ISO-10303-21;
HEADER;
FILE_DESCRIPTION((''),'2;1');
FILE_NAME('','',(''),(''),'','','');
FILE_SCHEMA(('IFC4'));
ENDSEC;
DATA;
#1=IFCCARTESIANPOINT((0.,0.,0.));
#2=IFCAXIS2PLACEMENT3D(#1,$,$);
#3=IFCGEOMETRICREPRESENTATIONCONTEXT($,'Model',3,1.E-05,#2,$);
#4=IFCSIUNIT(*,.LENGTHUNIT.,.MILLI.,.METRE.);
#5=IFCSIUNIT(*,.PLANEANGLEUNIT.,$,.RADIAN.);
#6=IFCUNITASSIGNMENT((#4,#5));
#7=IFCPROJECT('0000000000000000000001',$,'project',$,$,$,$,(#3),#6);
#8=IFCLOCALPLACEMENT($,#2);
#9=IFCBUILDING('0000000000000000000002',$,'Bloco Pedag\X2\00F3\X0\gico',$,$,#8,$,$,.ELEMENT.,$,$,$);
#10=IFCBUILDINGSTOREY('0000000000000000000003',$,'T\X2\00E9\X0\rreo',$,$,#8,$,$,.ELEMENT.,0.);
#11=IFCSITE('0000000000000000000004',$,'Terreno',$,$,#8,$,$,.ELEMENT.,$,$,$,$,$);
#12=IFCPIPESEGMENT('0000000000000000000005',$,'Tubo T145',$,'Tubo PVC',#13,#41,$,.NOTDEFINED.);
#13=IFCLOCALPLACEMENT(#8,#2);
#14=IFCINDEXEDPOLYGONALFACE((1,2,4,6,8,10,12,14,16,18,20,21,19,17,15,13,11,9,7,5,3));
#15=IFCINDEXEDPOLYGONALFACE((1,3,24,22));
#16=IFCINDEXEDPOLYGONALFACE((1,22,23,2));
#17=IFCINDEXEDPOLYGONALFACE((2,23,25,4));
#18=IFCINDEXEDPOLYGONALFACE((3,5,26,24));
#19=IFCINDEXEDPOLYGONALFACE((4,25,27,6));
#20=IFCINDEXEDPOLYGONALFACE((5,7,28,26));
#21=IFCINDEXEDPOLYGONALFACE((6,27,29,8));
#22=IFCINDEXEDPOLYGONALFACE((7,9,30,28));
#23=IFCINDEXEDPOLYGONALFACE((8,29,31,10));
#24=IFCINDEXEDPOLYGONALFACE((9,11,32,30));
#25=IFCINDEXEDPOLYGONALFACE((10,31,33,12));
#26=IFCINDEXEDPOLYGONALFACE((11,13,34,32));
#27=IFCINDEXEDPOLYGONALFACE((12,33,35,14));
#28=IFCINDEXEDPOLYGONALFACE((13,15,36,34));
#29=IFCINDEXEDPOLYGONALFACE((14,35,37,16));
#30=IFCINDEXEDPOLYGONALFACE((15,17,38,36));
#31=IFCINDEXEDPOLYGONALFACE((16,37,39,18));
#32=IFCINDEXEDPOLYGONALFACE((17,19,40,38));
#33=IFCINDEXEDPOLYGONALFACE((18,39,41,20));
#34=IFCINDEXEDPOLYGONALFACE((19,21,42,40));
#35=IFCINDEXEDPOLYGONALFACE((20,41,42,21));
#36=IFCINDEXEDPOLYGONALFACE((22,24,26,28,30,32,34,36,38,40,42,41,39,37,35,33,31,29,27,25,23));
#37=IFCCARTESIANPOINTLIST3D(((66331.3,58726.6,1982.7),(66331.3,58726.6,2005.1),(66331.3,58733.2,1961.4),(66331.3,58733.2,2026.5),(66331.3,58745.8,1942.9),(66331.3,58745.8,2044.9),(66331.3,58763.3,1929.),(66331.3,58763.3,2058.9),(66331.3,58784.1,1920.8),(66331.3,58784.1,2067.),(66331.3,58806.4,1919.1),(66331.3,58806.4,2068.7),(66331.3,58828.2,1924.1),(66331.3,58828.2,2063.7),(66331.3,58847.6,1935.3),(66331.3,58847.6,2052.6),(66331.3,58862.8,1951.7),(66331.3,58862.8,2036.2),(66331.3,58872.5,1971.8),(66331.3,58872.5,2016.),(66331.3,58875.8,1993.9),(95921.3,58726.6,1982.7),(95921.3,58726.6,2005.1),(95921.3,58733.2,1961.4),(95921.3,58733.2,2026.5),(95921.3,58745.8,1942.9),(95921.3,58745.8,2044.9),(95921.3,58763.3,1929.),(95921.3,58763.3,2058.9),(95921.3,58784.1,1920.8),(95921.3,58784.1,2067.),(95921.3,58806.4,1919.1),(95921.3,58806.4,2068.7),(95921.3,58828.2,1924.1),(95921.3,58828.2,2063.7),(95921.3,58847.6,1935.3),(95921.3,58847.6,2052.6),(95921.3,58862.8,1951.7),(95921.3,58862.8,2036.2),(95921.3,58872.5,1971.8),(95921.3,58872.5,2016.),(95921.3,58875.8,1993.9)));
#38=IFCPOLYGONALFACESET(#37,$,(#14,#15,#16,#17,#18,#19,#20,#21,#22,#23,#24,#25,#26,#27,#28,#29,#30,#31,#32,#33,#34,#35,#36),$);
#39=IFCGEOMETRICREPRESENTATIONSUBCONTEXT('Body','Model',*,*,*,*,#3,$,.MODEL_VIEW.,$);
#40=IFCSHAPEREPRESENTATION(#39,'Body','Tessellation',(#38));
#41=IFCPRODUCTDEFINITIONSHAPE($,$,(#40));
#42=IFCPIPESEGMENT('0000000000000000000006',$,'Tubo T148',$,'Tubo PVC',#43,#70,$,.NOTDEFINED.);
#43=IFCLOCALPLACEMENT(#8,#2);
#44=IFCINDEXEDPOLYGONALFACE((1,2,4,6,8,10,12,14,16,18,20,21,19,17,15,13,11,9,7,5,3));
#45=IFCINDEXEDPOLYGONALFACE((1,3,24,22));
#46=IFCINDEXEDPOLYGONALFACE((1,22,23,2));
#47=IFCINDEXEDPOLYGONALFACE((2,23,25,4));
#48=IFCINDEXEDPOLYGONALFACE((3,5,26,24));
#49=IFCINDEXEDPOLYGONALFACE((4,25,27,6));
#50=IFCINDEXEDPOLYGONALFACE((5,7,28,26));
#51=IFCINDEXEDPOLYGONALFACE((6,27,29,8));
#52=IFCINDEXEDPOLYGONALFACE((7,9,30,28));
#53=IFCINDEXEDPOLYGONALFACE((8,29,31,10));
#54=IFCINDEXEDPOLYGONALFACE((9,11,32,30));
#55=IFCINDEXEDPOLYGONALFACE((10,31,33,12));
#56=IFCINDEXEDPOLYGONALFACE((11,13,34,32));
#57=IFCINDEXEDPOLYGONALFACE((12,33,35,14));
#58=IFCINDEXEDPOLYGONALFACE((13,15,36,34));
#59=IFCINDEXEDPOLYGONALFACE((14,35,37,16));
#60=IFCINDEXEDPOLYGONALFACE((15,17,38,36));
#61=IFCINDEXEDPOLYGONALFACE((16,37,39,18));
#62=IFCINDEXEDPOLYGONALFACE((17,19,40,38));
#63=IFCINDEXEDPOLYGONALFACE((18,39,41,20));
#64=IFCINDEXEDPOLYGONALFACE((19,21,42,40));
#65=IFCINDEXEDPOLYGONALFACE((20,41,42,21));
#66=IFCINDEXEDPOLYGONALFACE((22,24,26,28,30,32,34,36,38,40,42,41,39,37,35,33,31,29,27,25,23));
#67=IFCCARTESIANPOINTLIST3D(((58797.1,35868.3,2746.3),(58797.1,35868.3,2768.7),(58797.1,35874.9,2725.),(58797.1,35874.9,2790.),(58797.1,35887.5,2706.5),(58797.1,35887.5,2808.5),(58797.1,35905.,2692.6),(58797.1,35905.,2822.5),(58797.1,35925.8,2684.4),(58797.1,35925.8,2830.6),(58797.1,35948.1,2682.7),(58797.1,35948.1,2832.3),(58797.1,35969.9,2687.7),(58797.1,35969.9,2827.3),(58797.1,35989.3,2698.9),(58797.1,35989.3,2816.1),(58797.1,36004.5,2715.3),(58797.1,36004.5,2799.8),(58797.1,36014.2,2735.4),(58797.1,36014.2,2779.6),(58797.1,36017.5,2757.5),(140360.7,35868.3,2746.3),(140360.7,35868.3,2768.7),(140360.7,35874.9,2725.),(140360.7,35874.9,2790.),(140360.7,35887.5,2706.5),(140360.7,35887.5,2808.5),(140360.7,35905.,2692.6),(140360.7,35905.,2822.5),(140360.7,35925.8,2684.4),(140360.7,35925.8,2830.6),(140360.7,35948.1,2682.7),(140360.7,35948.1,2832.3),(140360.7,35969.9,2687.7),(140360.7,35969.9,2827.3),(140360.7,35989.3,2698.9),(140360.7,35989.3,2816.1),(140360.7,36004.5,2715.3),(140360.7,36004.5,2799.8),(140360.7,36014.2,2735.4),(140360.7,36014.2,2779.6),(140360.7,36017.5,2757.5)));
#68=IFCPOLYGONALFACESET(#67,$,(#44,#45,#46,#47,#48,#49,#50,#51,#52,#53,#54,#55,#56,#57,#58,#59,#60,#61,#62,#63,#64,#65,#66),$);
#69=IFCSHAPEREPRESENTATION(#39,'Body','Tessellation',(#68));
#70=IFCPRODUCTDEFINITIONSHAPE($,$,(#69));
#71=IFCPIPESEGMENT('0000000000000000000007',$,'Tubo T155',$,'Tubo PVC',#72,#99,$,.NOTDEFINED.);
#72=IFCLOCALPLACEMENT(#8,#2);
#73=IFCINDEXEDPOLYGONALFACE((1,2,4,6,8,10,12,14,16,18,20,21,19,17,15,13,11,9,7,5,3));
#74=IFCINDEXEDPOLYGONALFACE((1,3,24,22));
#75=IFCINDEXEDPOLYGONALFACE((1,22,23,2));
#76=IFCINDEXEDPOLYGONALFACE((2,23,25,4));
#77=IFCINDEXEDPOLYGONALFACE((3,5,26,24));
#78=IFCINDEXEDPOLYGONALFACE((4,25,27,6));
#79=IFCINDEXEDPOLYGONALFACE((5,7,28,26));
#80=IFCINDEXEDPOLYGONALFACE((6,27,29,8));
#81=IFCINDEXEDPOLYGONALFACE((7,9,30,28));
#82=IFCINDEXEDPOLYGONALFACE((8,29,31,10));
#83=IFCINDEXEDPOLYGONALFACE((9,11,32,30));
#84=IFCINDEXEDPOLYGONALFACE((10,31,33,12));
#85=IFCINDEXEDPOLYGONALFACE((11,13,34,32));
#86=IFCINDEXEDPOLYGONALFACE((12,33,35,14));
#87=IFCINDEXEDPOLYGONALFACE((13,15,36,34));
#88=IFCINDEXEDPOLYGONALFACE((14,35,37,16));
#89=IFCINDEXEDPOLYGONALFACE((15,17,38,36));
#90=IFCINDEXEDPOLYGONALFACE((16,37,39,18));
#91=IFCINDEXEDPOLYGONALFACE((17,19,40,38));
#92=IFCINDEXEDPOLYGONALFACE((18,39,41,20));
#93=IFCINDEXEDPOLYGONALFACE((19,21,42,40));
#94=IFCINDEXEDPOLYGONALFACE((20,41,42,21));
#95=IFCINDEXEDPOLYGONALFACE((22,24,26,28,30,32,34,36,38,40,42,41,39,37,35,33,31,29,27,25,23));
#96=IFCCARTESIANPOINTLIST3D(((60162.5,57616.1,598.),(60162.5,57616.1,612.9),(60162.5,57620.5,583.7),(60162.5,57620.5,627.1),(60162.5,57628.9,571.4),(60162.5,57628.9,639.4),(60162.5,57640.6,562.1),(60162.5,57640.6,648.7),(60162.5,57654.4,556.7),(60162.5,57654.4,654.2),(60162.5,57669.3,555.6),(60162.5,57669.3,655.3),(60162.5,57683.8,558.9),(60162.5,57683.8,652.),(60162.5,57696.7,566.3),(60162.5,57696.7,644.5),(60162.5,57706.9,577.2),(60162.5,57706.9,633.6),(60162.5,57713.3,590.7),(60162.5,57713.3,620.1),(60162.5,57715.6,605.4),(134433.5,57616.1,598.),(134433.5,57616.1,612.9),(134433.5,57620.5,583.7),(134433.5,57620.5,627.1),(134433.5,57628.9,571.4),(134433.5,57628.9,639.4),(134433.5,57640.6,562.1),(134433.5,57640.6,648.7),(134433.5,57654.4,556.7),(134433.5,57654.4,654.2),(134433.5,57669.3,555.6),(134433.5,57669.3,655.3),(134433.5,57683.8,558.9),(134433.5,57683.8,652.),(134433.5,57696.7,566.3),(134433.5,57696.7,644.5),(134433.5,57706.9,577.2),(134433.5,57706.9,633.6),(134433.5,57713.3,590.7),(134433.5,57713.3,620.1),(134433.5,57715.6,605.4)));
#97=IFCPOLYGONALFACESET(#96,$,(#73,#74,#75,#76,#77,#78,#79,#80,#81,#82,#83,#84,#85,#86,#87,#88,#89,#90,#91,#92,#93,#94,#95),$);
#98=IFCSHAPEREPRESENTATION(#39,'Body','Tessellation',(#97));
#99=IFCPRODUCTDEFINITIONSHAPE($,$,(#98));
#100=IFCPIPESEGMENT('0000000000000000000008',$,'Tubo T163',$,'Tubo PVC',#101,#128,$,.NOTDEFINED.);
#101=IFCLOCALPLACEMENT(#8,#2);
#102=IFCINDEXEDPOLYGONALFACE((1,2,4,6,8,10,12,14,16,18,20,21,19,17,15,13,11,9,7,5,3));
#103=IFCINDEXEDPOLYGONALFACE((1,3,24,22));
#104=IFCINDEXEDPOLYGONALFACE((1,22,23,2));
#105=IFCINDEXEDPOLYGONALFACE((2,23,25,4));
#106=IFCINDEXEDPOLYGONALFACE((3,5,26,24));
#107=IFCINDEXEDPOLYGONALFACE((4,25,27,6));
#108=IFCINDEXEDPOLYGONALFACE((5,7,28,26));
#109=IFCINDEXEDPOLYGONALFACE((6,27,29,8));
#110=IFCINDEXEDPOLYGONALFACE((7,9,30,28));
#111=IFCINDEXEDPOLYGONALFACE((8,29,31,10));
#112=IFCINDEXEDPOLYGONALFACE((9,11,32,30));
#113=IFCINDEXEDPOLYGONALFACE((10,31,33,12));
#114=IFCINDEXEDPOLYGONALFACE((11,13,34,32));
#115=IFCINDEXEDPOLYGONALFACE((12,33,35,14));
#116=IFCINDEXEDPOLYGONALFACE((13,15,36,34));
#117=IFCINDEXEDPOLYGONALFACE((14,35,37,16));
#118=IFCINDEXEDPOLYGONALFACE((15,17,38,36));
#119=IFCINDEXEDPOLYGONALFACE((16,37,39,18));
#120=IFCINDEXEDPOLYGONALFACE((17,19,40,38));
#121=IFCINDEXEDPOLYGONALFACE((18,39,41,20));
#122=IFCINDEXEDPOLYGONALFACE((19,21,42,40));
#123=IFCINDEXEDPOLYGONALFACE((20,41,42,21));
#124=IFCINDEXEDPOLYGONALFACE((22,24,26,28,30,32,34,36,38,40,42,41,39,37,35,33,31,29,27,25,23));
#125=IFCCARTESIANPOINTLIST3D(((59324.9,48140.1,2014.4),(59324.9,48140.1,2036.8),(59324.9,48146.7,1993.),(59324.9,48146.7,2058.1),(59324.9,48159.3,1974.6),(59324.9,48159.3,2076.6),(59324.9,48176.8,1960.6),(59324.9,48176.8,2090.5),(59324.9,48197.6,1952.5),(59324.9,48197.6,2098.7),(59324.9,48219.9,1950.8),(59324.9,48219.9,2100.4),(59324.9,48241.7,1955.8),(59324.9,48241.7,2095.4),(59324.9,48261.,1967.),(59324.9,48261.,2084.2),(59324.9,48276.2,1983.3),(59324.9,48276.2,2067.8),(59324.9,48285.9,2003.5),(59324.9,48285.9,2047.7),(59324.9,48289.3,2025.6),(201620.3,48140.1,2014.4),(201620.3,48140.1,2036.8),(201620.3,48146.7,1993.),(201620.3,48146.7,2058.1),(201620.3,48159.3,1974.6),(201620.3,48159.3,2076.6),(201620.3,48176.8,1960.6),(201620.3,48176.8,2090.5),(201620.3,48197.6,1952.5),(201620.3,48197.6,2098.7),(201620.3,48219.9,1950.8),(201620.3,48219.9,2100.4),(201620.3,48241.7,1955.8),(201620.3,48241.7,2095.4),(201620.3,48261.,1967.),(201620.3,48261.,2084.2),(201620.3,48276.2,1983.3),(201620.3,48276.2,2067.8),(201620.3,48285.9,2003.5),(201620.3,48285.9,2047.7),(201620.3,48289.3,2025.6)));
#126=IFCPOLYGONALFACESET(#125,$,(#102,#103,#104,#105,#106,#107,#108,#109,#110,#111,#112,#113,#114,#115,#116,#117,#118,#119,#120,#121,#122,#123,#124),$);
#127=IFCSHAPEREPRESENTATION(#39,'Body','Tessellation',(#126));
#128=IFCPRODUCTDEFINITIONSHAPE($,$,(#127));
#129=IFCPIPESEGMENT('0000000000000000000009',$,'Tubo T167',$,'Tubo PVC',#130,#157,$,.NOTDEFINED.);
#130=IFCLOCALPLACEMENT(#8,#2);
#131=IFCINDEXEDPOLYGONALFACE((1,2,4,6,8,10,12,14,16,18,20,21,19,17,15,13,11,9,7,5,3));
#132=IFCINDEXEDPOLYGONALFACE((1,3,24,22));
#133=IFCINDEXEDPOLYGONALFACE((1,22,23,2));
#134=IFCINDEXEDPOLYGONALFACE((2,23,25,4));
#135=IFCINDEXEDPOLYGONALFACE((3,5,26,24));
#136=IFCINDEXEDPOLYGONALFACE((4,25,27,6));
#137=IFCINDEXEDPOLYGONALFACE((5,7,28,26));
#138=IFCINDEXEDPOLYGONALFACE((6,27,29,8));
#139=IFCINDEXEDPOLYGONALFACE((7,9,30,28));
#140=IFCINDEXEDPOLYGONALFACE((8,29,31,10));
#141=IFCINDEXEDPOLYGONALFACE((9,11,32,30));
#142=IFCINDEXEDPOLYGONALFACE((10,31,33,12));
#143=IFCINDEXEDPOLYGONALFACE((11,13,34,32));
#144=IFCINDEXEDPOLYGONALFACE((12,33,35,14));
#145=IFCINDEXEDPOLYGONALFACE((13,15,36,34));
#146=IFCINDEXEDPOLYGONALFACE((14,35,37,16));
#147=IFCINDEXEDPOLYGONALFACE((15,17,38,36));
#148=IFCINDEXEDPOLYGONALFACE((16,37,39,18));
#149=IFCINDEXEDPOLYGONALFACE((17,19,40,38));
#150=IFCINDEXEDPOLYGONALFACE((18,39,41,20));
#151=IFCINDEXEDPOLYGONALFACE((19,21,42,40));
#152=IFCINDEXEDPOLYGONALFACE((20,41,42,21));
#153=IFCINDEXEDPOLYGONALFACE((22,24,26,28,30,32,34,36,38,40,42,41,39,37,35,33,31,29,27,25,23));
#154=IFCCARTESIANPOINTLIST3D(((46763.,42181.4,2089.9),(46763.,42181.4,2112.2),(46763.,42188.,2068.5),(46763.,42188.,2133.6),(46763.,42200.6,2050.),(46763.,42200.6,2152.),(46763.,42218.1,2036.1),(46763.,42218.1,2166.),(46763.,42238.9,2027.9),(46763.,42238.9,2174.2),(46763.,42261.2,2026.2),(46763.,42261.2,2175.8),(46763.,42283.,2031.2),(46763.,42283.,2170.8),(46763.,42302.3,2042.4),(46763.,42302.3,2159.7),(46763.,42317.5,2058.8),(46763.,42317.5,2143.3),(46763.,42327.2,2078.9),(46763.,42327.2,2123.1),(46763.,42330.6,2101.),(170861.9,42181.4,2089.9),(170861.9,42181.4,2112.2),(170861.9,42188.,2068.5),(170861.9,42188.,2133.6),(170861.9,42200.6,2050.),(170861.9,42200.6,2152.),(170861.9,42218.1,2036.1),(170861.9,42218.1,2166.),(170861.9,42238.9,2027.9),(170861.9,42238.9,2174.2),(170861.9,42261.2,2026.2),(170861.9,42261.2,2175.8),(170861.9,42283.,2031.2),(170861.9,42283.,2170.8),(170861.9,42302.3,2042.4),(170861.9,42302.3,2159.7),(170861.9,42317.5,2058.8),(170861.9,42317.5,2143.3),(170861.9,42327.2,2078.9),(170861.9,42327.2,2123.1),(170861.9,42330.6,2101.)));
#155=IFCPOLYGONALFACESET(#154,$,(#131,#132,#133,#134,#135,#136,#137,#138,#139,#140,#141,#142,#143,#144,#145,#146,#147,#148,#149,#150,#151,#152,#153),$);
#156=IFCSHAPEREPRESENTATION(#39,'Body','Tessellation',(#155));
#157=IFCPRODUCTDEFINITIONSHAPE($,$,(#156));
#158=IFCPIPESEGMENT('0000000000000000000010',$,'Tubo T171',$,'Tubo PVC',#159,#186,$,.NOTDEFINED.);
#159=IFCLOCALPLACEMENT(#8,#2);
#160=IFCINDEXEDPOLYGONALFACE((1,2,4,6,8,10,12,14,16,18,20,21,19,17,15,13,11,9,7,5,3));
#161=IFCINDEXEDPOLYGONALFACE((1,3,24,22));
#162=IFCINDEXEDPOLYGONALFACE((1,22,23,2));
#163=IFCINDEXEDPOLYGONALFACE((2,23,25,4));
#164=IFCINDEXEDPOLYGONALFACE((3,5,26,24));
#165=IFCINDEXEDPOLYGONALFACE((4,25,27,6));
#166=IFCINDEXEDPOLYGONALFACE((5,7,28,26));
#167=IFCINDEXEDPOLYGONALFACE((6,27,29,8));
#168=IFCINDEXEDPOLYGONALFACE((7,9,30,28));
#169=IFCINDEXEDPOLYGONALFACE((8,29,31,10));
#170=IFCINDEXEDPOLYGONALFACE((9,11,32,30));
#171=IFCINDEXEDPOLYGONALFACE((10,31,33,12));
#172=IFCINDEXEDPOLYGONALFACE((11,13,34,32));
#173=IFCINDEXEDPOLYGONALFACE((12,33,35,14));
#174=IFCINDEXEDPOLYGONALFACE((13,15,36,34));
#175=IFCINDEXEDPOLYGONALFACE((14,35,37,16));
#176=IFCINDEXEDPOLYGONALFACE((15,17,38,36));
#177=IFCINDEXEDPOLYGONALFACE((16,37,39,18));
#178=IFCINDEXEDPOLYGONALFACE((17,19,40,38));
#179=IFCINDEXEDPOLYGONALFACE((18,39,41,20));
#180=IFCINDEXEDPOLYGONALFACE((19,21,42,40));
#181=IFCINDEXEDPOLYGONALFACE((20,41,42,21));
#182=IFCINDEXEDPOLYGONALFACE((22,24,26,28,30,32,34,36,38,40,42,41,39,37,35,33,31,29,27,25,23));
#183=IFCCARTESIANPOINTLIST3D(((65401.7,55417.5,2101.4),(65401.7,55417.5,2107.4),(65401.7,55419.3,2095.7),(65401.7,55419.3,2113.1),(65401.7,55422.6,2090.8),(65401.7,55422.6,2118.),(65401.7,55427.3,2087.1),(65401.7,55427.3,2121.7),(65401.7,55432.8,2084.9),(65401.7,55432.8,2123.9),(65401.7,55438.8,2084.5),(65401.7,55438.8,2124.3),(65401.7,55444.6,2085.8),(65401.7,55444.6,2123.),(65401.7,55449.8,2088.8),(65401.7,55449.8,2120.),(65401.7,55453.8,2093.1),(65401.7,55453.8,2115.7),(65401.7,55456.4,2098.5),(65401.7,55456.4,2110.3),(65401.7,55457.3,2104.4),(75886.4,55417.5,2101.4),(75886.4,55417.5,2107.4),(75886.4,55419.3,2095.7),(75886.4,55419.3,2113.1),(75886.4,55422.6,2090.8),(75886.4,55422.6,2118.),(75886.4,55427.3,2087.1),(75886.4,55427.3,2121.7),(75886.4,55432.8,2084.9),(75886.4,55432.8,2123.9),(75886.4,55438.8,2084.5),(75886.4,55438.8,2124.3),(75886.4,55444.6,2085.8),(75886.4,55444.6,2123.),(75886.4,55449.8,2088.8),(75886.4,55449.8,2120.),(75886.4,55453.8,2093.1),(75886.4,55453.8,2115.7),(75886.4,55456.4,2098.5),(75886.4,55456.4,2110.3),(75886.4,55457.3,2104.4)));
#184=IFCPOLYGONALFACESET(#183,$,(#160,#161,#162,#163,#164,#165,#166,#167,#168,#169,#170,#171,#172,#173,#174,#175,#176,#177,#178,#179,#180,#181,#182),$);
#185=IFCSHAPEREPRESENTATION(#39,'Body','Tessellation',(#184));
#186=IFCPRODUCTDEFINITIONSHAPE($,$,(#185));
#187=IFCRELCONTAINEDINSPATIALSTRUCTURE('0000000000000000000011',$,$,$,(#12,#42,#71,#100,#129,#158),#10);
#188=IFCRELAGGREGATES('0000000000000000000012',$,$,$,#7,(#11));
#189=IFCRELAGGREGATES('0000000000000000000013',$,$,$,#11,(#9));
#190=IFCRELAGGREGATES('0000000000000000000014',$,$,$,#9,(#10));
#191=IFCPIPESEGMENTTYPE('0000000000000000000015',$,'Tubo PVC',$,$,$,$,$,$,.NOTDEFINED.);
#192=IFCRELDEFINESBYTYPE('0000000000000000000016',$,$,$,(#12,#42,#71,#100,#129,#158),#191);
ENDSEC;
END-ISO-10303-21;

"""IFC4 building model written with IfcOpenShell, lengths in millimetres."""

from ifc_helpers import new_model, si_unit, frame, origin, origin_2d, place, context, subcontext, project, spatial, circle, extrude, type_object, element, save


model = new_model("IFC4")

# Units and contexts
model_context = context("Model", 3, precision=1e-05, world=origin())
body_context = subcontext(model_context, "Body", "Model", "MODEL_VIEW")
ifc_project = project(units=[si_unit("LENGTHUNIT", "METRE", prefix="MILLI"), si_unit("PLANEANGLEUNIT", "RADIAN")], contexts=[model_context])

# Site, building, storey
placement = place(None, origin())
site = spatial("IfcSite", under=ifc_project, at=placement, Name="Terreno", CompositionType="ELEMENT")
building = spatial("IfcBuilding", under=site, at=placement, Name="Bloco Pedagógico", CompositionType="ELEMENT")
storey = spatial("IfcBuildingStorey", under=building, at=placement, Name="Térreo", CompositionType="ELEMENT", Elevation=0.0)

# Pipe segments
pipe_segment_type = type_object("IfcPipeSegmentType", Name="Tubo PVC", PredefinedType="NOTDEFINED")
pipe_segment_1_placement = place(None, frame((66331.3, 58800.8, 1993.9), z_axis=(1.0, 0.0, 0.0), x_axis=(0.0, 1.0, 0.0)))
element("IfcPipeSegment", 1, at=pipe_segment_1_placement, inside=storey, type_object=pipe_segment_type, Name="Tubo T145", ObjectType="Tubo PVC", PredefinedType="NOTDEFINED", context=body_context, shape_type="SweptSolid", body=[
    extrude(circle(Radius=75.0, at=origin_2d()), None, (0.0, 0.0, 1.0), 29590.0),
])
pipe_segment_2_placement = place(None, frame((58797.1, 35942.5, 2757.5), z_axis=(1.0, 0.0, 0.0), x_axis=(0.0, 1.0, 0.0)))
element("IfcPipeSegment", 2, at=pipe_segment_2_placement, inside=storey, type_object=pipe_segment_type, Name="Tubo T148", ObjectType="Tubo PVC", PredefinedType="NOTDEFINED", context=body_context, shape_type="SweptSolid", body=[
    extrude(circle(Radius=75.0, at=origin_2d()), None, (0.0, 0.0, 1.0), 81563.6),
])
pipe_segment_3_placement = place(None, frame((60162.5, 57665.6, 605.4), z_axis=(1.0, 0.0, 0.0), x_axis=(0.0, 1.0, 0.0)))
element("IfcPipeSegment", 3, at=pipe_segment_3_placement, inside=storey, type_object=pipe_segment_type, Name="Tubo T155", ObjectType="Tubo PVC", PredefinedType="NOTDEFINED", context=body_context, shape_type="SweptSolid", body=[
    extrude(circle(Radius=50.0, at=origin_2d()), None, (0.0, 0.0, 1.0), 74270.9),
])
pipe_segment_4_placement = place(None, frame((59324.9, 48214.3, 2025.6), z_axis=(1.0, 0.0, 0.0), x_axis=(0.0, 1.0, 0.0)))
element("IfcPipeSegment", 4, at=pipe_segment_4_placement, inside=storey, type_object=pipe_segment_type, Name="Tubo T163", ObjectType="Tubo PVC", PredefinedType="NOTDEFINED", context=body_context, shape_type="SweptSolid", body=[
    extrude(circle(Radius=75.0, at=origin_2d()), None, (0.0, 0.0, 1.0), 142295.4),
])
pipe_segment_5_placement = place(None, frame((46763.0, 42255.6, 2101.0), z_axis=(1.0, 0.0, 0.0), x_axis=(0.0, 1.0, 0.0)))
element("IfcPipeSegment", 5, at=pipe_segment_5_placement, inside=storey, type_object=pipe_segment_type, Name="Tubo T167", ObjectType="Tubo PVC", PredefinedType="NOTDEFINED", context=body_context, shape_type="SweptSolid", body=[
    extrude(circle(Radius=75.0, at=origin_2d()), None, (0.0, 0.0, 1.0), 124098.9),
])
pipe_segment_6_placement = place(None, frame((65401.7, 55437.3, 2104.4), z_axis=(1.0, 0.0, 0.0), x_axis=(0.0, 1.0, 0.0)))
element("IfcPipeSegment", 6, at=pipe_segment_6_placement, inside=storey, type_object=pipe_segment_type, Name="Tubo T171", ObjectType="Tubo PVC", PredefinedType="NOTDEFINED", context=body_context, shape_type="SweptSolid", body=[
    extrude(circle(Radius=20.0, at=origin_2d()), None, (0.0, 0.0, 1.0), 10484.7),
])

save(model, "model.ifc")
